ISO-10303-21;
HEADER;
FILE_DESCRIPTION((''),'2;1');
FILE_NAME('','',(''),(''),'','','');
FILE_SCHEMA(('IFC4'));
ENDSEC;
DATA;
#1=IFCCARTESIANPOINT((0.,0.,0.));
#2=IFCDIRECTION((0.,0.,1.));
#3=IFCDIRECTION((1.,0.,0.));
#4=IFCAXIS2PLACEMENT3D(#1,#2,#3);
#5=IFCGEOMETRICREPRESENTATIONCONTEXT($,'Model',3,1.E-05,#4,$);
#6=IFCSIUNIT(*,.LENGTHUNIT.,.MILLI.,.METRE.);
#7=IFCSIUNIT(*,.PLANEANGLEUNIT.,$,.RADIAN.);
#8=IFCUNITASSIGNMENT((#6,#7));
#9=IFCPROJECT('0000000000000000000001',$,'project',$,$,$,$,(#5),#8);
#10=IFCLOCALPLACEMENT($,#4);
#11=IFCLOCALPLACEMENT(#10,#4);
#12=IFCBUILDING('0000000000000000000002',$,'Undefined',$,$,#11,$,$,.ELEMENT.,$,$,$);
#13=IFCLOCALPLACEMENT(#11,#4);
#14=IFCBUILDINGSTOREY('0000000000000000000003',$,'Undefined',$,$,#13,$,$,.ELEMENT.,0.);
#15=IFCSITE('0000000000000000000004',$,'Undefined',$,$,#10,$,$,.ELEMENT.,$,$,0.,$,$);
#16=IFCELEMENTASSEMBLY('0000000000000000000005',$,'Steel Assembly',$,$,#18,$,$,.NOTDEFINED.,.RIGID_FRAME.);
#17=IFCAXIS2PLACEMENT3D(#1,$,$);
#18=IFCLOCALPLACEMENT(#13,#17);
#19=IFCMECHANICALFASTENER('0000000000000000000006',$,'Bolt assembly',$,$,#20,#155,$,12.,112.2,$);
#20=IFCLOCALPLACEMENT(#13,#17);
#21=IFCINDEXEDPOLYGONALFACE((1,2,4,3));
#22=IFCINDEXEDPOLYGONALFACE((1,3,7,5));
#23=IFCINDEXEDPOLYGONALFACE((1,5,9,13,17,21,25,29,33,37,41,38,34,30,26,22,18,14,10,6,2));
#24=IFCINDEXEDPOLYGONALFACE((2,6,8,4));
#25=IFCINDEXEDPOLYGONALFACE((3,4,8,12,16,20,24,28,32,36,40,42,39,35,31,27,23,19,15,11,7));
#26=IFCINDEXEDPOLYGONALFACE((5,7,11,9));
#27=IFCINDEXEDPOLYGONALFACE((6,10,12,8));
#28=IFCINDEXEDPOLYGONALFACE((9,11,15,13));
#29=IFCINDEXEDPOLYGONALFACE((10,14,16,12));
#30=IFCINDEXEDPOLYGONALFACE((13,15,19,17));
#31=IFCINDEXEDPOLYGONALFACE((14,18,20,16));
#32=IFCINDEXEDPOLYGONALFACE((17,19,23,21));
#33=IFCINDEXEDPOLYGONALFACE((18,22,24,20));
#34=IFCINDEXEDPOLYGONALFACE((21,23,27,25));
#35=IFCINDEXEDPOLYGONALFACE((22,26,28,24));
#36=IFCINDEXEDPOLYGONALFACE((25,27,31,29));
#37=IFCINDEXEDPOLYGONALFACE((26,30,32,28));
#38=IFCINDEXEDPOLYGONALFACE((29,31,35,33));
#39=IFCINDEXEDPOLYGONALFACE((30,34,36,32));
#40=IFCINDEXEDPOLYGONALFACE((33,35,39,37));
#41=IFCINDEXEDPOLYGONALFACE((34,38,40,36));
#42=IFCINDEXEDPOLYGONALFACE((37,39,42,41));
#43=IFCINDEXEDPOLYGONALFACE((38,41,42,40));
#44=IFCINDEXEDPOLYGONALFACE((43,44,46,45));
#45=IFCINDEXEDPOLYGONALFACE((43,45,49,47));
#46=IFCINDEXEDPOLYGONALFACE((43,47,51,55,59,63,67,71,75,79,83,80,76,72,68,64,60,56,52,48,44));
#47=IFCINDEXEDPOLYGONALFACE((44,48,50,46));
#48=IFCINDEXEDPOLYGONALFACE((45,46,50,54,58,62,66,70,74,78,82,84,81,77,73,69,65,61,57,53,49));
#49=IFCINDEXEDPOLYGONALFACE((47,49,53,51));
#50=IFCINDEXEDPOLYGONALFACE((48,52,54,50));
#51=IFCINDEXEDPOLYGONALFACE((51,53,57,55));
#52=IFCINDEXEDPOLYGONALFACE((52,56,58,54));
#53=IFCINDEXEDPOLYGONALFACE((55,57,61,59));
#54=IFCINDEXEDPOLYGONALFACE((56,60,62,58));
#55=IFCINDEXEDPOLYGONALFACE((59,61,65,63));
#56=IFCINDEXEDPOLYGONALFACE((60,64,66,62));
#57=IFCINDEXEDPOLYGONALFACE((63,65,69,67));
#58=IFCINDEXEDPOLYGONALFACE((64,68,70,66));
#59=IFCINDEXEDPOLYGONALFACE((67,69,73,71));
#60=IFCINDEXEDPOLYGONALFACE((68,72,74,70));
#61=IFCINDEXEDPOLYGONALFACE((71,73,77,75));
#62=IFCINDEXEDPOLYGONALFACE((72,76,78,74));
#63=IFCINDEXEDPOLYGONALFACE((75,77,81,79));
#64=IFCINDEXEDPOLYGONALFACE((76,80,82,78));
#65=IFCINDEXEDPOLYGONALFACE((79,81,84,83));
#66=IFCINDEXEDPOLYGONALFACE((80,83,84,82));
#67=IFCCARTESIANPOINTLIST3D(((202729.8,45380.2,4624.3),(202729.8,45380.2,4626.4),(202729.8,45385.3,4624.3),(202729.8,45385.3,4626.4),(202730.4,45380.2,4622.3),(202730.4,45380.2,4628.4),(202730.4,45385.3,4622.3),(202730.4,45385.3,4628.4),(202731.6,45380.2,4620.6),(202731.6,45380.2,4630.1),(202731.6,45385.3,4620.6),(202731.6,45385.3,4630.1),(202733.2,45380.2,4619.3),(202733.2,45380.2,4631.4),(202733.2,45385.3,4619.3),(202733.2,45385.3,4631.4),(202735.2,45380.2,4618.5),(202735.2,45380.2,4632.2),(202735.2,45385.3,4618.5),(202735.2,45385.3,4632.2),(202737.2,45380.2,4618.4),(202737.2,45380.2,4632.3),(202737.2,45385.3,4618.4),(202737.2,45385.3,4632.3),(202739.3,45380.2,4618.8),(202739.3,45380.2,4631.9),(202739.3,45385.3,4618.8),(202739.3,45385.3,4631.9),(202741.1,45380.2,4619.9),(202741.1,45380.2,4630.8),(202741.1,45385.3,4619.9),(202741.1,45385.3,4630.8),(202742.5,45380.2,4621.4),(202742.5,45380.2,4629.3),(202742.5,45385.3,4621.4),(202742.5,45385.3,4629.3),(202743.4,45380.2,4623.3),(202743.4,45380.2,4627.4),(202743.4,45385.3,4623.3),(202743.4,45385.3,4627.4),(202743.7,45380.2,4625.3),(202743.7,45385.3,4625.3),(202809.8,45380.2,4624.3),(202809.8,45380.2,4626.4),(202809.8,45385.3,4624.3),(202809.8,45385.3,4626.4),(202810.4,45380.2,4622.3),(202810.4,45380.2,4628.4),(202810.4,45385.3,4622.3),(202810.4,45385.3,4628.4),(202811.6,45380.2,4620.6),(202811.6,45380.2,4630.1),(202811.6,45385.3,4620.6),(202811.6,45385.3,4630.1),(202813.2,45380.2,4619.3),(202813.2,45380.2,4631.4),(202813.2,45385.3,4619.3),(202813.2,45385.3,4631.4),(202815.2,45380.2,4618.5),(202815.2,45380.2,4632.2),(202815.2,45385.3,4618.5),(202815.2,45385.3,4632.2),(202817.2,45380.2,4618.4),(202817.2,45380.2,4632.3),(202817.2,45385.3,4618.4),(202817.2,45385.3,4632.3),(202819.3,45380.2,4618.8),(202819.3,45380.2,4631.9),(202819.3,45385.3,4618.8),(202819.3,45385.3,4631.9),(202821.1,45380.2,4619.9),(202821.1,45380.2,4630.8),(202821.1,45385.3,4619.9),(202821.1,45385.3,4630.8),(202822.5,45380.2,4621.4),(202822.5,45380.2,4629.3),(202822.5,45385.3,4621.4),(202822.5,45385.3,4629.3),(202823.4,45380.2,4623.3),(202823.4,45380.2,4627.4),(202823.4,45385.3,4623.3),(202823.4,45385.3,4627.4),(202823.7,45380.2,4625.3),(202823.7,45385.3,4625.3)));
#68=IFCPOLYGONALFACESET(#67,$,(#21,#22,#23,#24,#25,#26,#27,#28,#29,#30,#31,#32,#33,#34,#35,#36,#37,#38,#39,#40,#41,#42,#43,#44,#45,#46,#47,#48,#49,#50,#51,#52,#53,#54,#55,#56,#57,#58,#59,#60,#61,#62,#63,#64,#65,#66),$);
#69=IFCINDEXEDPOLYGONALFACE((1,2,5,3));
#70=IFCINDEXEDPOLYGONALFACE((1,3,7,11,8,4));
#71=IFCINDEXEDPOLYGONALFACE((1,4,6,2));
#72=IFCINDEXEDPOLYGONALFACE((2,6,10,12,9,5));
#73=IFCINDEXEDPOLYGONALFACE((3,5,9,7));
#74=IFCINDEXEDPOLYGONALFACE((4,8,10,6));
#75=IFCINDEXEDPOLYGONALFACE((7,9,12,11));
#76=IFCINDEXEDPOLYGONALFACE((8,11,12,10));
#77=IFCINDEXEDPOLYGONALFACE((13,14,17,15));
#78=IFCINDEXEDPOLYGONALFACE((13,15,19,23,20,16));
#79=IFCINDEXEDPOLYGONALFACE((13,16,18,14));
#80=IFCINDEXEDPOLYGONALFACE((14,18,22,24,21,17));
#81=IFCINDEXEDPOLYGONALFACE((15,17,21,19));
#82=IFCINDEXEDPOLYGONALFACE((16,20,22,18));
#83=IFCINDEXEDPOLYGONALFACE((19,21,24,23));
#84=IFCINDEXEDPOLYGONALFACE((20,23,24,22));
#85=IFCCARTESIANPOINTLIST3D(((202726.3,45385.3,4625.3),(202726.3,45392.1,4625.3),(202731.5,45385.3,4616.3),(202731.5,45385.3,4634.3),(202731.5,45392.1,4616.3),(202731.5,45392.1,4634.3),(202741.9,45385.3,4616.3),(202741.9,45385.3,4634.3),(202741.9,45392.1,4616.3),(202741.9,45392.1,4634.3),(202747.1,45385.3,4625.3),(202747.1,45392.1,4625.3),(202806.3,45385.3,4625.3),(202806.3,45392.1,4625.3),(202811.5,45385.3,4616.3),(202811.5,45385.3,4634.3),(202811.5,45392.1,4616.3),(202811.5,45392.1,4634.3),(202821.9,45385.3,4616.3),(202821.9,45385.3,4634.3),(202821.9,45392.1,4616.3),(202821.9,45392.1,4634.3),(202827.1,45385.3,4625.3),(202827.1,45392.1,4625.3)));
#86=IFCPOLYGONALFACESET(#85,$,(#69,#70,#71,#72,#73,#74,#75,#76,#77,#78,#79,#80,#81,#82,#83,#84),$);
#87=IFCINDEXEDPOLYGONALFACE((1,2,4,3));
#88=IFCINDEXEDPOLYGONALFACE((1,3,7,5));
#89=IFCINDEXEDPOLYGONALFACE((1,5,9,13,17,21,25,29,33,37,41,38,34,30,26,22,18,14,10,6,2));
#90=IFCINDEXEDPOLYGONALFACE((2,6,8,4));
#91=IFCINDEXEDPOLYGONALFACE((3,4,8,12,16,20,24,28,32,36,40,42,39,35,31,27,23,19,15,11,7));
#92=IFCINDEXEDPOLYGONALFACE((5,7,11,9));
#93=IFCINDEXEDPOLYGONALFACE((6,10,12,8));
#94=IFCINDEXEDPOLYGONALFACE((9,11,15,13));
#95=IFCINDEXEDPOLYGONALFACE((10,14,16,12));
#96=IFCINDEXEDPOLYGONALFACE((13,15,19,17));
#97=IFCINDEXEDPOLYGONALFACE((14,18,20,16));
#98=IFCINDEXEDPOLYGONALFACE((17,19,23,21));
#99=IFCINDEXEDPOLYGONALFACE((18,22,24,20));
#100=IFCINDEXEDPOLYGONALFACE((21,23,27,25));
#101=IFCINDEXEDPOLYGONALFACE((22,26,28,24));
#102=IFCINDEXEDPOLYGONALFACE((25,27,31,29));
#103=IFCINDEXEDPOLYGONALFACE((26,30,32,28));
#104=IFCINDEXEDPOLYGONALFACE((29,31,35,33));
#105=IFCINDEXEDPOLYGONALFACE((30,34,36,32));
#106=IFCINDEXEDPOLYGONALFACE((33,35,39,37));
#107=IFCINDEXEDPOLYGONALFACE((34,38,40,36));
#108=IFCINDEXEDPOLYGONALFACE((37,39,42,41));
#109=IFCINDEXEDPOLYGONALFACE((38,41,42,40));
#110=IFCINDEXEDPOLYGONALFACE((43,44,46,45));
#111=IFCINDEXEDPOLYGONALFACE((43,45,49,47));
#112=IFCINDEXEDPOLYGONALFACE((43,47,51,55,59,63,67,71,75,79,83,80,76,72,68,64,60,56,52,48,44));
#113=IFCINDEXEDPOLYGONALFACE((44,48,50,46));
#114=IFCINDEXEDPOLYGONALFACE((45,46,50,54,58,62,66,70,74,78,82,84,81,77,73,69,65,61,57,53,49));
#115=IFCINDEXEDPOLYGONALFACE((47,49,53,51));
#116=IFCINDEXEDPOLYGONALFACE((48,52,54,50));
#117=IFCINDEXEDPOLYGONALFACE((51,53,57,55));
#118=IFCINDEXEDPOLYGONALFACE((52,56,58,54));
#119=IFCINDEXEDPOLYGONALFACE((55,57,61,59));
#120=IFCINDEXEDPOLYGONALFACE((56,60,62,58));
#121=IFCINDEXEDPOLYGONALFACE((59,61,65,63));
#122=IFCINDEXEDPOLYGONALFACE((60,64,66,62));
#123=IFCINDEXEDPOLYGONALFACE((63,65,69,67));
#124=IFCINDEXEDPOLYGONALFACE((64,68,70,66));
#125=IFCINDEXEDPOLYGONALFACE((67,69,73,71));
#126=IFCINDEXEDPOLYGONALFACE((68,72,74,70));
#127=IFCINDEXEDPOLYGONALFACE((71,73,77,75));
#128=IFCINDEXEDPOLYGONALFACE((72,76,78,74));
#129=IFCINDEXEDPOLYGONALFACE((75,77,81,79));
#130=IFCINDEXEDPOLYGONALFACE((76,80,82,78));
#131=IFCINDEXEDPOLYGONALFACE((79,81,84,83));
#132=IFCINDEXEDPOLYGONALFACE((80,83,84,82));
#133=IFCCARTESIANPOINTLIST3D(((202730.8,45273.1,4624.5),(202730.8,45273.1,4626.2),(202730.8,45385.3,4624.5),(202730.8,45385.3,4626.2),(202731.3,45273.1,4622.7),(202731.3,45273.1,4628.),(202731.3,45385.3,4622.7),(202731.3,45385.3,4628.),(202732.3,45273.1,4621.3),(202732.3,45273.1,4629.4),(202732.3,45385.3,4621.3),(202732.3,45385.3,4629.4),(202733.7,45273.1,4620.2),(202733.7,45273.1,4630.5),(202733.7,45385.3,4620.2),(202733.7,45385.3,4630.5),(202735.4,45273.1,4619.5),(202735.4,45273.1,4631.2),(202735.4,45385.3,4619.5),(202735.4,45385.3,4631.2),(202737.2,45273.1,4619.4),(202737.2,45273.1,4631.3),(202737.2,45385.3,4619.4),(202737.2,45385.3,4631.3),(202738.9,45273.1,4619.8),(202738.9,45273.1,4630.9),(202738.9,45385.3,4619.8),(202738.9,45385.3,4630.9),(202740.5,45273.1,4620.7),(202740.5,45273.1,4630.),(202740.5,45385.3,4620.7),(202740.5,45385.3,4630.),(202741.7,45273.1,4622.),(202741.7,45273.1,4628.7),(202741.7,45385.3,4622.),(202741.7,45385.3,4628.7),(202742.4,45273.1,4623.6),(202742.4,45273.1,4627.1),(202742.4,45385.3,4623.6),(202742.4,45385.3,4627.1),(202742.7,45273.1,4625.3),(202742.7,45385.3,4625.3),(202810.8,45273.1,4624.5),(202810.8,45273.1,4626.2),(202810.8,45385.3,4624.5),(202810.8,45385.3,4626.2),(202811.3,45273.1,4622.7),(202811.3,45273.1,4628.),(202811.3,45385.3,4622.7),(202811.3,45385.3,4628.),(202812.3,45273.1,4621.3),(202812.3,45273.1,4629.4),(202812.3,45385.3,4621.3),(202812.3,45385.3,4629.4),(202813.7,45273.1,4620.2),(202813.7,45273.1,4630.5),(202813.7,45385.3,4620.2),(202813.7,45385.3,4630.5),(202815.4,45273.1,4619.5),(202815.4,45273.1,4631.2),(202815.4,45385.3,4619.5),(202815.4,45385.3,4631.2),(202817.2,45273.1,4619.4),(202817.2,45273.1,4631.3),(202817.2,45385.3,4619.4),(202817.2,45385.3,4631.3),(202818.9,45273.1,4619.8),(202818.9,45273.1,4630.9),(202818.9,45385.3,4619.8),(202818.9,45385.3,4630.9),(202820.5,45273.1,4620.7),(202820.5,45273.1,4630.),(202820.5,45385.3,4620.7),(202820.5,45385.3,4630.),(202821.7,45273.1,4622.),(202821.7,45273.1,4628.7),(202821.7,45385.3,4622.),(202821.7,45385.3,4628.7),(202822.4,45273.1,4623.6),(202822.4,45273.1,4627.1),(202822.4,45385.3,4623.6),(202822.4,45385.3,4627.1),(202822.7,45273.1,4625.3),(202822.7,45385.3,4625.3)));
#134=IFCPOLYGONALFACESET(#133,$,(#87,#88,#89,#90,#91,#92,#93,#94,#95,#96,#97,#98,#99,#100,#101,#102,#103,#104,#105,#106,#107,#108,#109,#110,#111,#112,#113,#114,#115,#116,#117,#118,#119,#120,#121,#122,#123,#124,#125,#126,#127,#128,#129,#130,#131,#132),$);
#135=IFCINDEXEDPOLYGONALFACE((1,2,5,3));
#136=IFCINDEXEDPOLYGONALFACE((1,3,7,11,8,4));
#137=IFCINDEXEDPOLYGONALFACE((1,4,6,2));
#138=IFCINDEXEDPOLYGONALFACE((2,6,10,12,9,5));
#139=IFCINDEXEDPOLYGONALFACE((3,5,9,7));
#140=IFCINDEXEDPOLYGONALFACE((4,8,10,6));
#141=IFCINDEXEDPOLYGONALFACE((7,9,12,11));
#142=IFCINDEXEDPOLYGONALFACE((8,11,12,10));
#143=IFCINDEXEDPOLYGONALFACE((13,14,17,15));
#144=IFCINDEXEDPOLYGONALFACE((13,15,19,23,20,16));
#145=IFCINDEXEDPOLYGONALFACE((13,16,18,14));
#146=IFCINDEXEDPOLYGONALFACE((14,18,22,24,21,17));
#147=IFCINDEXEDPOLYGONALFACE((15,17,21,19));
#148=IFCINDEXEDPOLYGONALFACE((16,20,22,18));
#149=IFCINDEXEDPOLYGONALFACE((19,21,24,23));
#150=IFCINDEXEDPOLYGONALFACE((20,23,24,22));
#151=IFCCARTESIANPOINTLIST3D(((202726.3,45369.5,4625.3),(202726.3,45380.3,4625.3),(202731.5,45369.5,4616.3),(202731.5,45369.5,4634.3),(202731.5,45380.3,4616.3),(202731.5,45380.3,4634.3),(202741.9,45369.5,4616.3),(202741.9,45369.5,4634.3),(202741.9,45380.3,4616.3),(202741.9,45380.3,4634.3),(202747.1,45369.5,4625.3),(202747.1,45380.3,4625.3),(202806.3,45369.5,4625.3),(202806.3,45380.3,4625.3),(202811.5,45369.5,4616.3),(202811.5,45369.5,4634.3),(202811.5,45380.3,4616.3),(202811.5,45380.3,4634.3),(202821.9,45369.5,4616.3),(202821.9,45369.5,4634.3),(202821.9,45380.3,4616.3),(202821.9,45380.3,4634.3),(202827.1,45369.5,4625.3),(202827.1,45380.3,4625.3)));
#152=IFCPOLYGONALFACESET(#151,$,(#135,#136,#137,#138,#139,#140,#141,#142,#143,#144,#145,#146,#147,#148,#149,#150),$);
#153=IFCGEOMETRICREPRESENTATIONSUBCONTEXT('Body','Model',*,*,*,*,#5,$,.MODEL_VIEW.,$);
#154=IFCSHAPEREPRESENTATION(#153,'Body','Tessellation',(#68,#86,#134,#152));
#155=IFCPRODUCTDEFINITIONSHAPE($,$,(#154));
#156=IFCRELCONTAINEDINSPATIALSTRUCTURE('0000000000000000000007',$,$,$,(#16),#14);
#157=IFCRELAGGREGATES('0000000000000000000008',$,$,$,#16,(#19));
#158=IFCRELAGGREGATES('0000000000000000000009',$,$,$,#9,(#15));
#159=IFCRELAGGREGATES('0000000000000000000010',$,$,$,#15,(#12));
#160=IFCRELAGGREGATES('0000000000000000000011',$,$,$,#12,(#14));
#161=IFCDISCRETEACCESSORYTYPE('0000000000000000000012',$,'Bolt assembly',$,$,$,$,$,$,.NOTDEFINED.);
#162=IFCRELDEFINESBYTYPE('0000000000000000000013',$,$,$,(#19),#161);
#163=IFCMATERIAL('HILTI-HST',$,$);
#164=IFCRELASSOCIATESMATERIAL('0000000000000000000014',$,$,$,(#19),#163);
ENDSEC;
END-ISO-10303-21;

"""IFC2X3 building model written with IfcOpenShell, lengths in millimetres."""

from ifc_helpers import new_model, si_unit, frame, origin_with_axes, origin_2d_with_axis, place, context, subcontext, project, spatial, polyline, circle, outline, extrude, source, transform, mapped, material, type_object, element, aggregate, save


model = new_model("IFC2X3")

# Units and contexts
model_context = context("Model", 3, precision=1e-05, world=origin_with_axes())
body_context = subcontext(model_context, "Body", "Model", "MODEL_VIEW")
ifc_project = project(units=[si_unit("LENGTHUNIT", "METRE", prefix="MILLI"), si_unit("PLANEANGLEUNIT", "RADIAN")], contexts=[model_context])

# Site, building, storey
site_placement = place(None, origin_with_axes())
site = spatial("IfcSite", under=ifc_project, at=site_placement, Name="Undefined", CompositionType="ELEMENT", RefElevation=0.0)
building_placement = place(site_placement, origin_with_axes())
building = spatial("IfcBuilding", under=site, at=building_placement, Name="Undefined", CompositionType="ELEMENT")
storey_placement = place(building_placement, origin_with_axes())
storey = spatial("IfcBuildingStorey", under=building, at=storey_placement, Name="Undefined", CompositionType="ELEMENT", Elevation=0.0)

# Element assembly
assembly_1_placement = place(storey_placement, origin_with_axes())
assembly_1 = element("IfcElementAssembly", 1, at=assembly_1_placement, inside=storey, Name="Steel Assembly", AssemblyPlace="NOTDEFINED", PredefinedType="RIGID_FRAME")

# Mechanical fastener
ifc_material_1 = material(Name="HILTI-HST")
discrete_accessory_type_1 = type_object("IfcDiscreteAccessoryType", Name="Bolt assembly")
shared_shape_1 = source(origin_with_axes(), body_context, "Body", "SweptSolid", [
    extrude(circle(Radius=7.0, at=origin_2d_with_axis()), frame((0.0, 0.0, 0.0), z_axis=(0.0, 1.0, 0.0), x_axis=(1.0, 0.0, 0.0)), (0.0, 0.0, 1.0), 5.1),
    extrude(outline(polyline([(10.4, 0.0), (5.2, 9.0), (-5.2, 9.0), (-10.4, 0.0), (-5.2, -9.0), (5.2, -9.0), (10.4, 0.0)])), frame((0.0, -6.8, 0.0), z_axis=(0.0, 1.0, 0.0), x_axis=(1.0, 0.0, 0.0)), (0.0, 0.0, 1.0), 6.8),
    extrude(circle(Radius=6.0, at=origin_2d_with_axis()), frame((0.0, 0.0, 0.0), z_axis=(0.0, 1.0, 0.0), x_axis=(1.0, 0.0, 0.0)), (0.0, 0.0, 1.0), 112.2),
    extrude(outline(polyline([(10.4, 0.0), (5.2, 9.0), (-5.2, 9.0), (-10.4, 0.0), (-5.2, -9.0), (5.2, -9.0), (10.4, 0.0)])), frame((0.0, 5.0, 0.0), z_axis=(0.0, 1.0, 0.0), x_axis=(1.0, 0.0, 0.0)), (0.0, 0.0, 1.0), 10.8),
])
mechanical_fastener_1_placement = place(assembly_1_placement, frame((202736.7, 45385.3, 4625.3), z_axis=(0.0, 0.0, -1.0), x_axis=(1.0, 0.0, 0.0)))
mechanical_fastener_1 = element("IfcMechanicalFastener", 2, at=mechanical_fastener_1_placement, type_object=discrete_accessory_type_1, material=ifc_material_1, Name="Bolt assembly", NominalDiameter=12.0, NominalLength=112.2, context=body_context, shape_type="MappedRepresentation", body=[
    mapped(shared_shape_1, transform((0.0, 0.0, 0.0))),
    mapped(shared_shape_1, transform((80.0, 0.0, 0.0))),
])
aggregate(assembly_1, [mechanical_fastener_1])

save(model, "model.ifc")
